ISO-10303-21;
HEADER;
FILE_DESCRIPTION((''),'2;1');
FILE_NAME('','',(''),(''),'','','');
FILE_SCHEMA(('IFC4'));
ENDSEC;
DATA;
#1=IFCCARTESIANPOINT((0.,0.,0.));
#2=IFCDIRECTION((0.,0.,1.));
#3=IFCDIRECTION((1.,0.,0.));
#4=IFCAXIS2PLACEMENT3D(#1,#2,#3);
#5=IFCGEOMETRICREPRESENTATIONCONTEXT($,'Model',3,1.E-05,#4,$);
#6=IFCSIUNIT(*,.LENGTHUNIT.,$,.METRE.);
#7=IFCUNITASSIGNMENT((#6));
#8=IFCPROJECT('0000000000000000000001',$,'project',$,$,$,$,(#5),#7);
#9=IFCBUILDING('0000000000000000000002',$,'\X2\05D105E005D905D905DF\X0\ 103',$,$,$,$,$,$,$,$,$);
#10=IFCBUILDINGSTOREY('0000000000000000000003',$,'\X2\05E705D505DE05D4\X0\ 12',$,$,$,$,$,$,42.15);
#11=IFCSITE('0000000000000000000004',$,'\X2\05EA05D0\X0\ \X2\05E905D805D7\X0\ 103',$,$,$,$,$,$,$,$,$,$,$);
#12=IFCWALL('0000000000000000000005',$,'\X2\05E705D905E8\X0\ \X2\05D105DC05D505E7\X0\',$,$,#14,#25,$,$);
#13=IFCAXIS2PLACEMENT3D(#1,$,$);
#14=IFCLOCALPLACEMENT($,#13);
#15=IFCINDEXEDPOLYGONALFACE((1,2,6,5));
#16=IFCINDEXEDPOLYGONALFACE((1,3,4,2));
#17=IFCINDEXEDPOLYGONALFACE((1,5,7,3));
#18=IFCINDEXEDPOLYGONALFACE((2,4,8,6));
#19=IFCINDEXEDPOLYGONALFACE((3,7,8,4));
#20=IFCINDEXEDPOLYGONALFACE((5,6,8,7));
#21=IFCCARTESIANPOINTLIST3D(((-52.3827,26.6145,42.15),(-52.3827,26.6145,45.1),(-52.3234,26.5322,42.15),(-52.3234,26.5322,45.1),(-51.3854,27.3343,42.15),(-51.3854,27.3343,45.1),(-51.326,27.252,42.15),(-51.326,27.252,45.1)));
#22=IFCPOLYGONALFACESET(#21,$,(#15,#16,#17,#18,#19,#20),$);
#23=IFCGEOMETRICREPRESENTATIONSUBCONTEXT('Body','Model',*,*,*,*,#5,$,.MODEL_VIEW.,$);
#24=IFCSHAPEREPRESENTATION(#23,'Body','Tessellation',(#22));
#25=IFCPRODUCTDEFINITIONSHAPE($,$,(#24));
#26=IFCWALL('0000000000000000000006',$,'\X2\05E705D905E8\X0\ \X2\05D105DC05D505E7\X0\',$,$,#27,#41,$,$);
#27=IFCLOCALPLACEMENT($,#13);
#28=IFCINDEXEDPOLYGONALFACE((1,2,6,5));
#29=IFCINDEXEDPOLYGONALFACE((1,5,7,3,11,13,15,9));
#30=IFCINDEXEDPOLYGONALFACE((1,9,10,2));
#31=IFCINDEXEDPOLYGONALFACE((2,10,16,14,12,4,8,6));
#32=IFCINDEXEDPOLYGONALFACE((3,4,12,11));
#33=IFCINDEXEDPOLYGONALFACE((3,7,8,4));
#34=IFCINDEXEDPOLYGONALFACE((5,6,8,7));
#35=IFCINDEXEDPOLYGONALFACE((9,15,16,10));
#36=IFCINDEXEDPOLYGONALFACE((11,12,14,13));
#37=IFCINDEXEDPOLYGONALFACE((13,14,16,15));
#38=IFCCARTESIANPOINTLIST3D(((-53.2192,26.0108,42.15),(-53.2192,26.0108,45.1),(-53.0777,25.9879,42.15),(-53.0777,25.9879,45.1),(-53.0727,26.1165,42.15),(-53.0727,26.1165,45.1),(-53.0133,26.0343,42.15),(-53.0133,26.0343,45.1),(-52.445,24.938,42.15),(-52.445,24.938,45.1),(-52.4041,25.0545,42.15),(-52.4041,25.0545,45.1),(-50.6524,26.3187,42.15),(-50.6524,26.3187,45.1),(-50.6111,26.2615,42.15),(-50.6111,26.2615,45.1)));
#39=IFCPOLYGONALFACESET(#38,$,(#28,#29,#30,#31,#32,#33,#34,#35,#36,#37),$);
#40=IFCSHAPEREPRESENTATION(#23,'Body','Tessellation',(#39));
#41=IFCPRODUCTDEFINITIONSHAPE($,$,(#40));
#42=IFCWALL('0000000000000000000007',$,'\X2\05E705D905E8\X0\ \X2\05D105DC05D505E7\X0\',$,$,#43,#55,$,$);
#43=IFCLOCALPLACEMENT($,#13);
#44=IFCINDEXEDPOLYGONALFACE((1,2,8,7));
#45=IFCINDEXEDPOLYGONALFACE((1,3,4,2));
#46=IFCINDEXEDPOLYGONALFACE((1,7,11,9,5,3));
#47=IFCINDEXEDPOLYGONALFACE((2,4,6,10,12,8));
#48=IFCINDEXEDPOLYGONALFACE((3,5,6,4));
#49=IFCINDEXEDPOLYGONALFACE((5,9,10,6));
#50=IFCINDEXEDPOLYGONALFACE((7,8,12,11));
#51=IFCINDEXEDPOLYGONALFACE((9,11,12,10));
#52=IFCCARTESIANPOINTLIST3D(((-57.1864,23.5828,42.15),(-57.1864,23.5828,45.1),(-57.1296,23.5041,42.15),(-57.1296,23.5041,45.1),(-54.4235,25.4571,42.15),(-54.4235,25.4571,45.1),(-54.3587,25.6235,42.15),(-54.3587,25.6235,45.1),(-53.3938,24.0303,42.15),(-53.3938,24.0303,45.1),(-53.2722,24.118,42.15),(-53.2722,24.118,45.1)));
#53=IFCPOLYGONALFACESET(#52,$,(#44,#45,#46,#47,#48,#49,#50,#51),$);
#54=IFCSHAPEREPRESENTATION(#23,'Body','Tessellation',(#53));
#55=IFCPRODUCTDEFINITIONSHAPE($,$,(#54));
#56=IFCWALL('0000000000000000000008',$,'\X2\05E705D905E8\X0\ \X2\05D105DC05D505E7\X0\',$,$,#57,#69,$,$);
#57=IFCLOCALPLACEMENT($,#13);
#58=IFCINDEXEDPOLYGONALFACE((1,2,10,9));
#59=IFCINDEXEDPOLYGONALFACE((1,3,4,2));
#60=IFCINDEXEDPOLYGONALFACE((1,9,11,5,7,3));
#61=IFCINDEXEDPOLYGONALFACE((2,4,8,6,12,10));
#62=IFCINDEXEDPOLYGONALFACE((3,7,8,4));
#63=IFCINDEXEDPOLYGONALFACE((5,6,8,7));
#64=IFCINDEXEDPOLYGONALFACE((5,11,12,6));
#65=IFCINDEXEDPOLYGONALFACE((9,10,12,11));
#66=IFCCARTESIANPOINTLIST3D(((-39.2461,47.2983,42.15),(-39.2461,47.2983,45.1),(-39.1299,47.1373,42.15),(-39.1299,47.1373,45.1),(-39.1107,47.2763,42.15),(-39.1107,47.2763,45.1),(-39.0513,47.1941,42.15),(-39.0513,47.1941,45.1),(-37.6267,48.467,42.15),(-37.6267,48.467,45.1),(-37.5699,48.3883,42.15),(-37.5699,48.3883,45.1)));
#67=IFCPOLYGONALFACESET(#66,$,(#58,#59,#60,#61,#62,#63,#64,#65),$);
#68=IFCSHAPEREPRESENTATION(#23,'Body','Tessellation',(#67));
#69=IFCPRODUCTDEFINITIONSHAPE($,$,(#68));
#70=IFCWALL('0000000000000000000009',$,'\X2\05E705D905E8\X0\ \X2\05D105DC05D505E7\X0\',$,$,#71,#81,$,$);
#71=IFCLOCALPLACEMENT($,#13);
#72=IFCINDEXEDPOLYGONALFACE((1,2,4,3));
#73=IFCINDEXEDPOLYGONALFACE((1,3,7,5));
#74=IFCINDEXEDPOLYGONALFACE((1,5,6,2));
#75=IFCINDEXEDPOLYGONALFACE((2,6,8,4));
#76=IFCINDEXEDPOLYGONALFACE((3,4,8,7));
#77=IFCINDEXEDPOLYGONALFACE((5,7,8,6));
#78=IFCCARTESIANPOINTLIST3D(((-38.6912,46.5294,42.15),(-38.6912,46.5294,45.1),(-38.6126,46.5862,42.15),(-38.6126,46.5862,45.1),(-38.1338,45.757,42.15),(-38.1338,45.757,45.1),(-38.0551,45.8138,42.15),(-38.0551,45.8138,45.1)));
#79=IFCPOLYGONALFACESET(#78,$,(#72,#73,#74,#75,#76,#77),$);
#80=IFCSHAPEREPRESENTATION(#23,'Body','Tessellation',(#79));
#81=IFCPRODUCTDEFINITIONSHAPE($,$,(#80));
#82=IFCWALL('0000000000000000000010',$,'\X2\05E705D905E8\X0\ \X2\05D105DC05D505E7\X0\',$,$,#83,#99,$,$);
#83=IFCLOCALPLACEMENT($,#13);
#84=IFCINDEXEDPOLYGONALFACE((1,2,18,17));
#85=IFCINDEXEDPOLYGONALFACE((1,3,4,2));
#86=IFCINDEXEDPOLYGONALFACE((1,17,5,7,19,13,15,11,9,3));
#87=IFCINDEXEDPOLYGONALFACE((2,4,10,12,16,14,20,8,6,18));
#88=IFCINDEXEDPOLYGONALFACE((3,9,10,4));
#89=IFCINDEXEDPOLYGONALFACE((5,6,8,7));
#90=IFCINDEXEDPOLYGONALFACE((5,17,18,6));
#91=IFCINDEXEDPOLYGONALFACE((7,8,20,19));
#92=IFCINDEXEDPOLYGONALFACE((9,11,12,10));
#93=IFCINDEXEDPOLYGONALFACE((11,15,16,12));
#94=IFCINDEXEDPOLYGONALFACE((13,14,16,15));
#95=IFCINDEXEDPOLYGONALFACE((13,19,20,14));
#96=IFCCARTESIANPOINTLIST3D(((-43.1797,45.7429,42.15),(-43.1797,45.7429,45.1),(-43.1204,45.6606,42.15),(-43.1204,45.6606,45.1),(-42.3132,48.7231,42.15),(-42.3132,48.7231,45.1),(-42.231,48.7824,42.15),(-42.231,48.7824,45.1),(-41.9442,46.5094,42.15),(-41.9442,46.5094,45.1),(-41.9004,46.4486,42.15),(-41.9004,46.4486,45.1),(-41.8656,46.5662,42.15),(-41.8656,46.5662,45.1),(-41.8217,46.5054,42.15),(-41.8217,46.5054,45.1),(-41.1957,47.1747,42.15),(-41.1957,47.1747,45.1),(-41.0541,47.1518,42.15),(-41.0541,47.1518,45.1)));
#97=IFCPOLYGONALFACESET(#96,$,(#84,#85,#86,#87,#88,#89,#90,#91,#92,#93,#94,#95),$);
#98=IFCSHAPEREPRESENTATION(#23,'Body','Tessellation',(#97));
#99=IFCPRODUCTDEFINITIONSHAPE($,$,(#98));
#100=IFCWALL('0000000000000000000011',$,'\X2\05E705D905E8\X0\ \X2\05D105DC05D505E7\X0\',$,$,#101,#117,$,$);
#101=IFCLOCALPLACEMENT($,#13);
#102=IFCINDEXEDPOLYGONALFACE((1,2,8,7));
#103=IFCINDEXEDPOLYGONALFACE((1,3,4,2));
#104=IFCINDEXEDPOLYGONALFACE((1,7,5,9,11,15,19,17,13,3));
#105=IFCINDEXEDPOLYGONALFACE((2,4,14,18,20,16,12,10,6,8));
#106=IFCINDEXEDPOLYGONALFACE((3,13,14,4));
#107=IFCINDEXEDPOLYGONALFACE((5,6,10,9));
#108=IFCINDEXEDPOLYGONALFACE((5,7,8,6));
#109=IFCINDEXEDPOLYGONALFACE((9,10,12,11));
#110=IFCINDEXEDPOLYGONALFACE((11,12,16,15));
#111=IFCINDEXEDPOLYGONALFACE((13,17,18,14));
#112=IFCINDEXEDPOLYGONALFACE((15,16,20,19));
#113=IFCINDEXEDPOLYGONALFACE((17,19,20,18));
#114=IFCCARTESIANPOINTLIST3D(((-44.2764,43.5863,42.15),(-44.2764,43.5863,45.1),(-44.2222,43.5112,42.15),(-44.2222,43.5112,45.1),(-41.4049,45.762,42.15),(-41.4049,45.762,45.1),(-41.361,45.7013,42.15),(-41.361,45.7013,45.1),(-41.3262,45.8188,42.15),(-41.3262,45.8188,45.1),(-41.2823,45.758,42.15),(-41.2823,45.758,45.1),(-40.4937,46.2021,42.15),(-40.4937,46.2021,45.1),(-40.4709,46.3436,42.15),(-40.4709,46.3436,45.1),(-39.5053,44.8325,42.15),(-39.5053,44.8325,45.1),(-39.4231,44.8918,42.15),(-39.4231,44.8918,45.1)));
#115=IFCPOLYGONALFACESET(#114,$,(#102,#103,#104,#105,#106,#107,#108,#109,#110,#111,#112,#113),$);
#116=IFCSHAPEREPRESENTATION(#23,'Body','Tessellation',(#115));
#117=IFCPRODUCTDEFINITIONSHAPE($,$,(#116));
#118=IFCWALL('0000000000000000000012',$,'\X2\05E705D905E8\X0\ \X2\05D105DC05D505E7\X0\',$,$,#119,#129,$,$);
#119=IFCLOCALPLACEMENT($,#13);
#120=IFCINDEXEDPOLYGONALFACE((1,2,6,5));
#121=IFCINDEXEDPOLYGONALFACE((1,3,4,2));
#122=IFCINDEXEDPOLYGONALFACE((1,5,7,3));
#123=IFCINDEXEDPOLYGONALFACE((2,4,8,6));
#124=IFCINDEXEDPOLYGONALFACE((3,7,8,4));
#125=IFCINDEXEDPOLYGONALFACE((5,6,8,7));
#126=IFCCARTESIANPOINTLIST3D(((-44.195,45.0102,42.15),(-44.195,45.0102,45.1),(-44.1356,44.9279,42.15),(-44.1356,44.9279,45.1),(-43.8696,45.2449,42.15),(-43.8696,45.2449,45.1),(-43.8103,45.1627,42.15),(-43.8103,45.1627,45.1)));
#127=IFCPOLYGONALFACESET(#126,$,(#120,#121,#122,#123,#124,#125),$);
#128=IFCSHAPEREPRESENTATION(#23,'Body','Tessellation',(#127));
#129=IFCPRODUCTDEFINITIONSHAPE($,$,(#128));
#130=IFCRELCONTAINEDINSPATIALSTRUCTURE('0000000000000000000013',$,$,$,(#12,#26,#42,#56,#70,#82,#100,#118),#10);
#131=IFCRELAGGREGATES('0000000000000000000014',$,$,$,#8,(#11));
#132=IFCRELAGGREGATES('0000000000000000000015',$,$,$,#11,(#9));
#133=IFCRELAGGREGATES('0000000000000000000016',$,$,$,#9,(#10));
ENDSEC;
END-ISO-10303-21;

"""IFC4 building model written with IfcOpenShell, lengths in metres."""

from ifc_helpers import new_model, si_unit, frame, origin_with_axes, context, subcontext, project, spatial, polyline, outline, extrude, element, save


model = new_model("IFC4")

# Units and contexts
model_context = context("Model", 3, precision=1e-05, world=origin_with_axes())
body_context = subcontext(model_context, "Body", "Model", "MODEL_VIEW")
ifc_project = project(units=[si_unit("LENGTHUNIT", "METRE")], contexts=[model_context])

# Site, building, storey
site = spatial("IfcSite", under=ifc_project, Name="תא שטח 103")
building = spatial("IfcBuilding", under=site, Name="בניין 103")
storey = spatial("IfcBuildingStorey", under=building, Name="קומה 12", Elevation=42.15)

# Walls
element("IfcWall", 1, inside=storey, Name="קיר בלוק", context=body_context, shape_type="SweptSolid", body=[
    extrude(outline(polyline([(-52.3827, 26.6145), (-51.3854, 27.3343), (-51.326, 27.252), (-52.3234, 26.5322), (-52.3827, 26.6145)])), frame((0.0, 0.0, 42.15)), (0.0, 0.0, 1.0), 2.95),
])
element("IfcWall", 2, inside=storey, Name="קיר בלוק", context=body_context, shape_type="SweptSolid", body=[
    extrude(outline(polyline([(-53.2192, 26.0108), (-53.0727, 26.1165), (-53.0133, 26.0343), (-53.0777, 25.9879), (-52.4041, 25.0545), (-50.6524, 26.3187), (-50.6111, 26.2615), (-52.445, 24.938), (-53.2192, 26.0108)])), frame((0.0, 0.0, 42.15)), (0.0, 0.0, 1.0), 2.95),
])
element("IfcWall", 3, inside=storey, Name="קיר בלוק", context=body_context, shape_type="SweptSolid", body=[
    extrude(outline(polyline([(-53.3938, 24.0303), (-54.4235, 25.4571), (-57.1296, 23.5041), (-57.1864, 23.5828), (-54.3587, 25.6235), (-53.2722, 24.118), (-53.3938, 24.0303)])), frame((0.0, 0.0, 42.15)), (0.0, 0.0, 1.0), 2.95),
])
element("IfcWall", 4, inside=storey, Name="קיר בלוק", context=body_context, shape_type="SweptSolid", body=[
    extrude(outline(polyline([(-39.1299, 47.1373), (-39.2461, 47.2983), (-37.6267, 48.467), (-37.5699, 48.3883), (-39.1107, 47.2763), (-39.0513, 47.1941), (-39.1299, 47.1373)])), frame((0.0, 0.0, 42.15)), (0.0, 0.0, 1.0), 2.95),
])
element("IfcWall", 5, inside=storey, Name="קיר בלוק", context=body_context, shape_type="SweptSolid", body=[
    extrude(outline(polyline([(-38.6126, 46.5862), (-38.0551, 45.8138), (-38.1338, 45.757), (-38.6912, 46.5294), (-38.6126, 46.5862)])), frame((0.0, 0.0, 42.15)), (0.0, 0.0, 1.0), 2.95),
])
element("IfcWall", 6, inside=storey, Name="קיר בלוק", context=body_context, shape_type="SweptSolid", body=[
    extrude(outline(polyline([(-41.9004, 46.4486), (-41.9442, 46.5094), (-43.1204, 45.6606), (-43.1797, 45.7429), (-41.1957, 47.1747), (-42.3132, 48.7231), (-42.231, 48.7824), (-41.0541, 47.1518), (-41.8656, 46.5662), (-41.8217, 46.5054), (-41.9004, 46.4486)])), frame((0.0, 0.0, 42.15)), (0.0, 0.0, 1.0), 2.95),
])
element("IfcWall", 7, inside=storey, Name="קיר בלוק", context=body_context, shape_type="SweptSolid", body=[
    extrude(outline(polyline([(-44.2764, 43.5863), (-41.361, 45.7013), (-41.4049, 45.762), (-41.3262, 45.8188), (-41.2823, 45.758), (-40.4709, 46.3436), (-39.4231, 44.8918), (-39.5053, 44.8325), (-40.4937, 46.2021), (-44.2222, 43.5112), (-44.2764, 43.5863)])), frame((0.0, 0.0, 42.15)), (0.0, 0.0, 1.0), 2.95),
])
element("IfcWall", 8, inside=storey, Name="קיר בלוק", context=body_context, shape_type="SweptSolid", body=[
    extrude(outline(polyline([(-43.8103, 45.1627), (-44.1356, 44.9279), (-44.195, 45.0102), (-43.8696, 45.2449), (-43.8103, 45.1627)])), frame((0.0, 0.0, 42.15)), (0.0, 0.0, 1.0), 2.95),
])

save(model, "model.ifc")
